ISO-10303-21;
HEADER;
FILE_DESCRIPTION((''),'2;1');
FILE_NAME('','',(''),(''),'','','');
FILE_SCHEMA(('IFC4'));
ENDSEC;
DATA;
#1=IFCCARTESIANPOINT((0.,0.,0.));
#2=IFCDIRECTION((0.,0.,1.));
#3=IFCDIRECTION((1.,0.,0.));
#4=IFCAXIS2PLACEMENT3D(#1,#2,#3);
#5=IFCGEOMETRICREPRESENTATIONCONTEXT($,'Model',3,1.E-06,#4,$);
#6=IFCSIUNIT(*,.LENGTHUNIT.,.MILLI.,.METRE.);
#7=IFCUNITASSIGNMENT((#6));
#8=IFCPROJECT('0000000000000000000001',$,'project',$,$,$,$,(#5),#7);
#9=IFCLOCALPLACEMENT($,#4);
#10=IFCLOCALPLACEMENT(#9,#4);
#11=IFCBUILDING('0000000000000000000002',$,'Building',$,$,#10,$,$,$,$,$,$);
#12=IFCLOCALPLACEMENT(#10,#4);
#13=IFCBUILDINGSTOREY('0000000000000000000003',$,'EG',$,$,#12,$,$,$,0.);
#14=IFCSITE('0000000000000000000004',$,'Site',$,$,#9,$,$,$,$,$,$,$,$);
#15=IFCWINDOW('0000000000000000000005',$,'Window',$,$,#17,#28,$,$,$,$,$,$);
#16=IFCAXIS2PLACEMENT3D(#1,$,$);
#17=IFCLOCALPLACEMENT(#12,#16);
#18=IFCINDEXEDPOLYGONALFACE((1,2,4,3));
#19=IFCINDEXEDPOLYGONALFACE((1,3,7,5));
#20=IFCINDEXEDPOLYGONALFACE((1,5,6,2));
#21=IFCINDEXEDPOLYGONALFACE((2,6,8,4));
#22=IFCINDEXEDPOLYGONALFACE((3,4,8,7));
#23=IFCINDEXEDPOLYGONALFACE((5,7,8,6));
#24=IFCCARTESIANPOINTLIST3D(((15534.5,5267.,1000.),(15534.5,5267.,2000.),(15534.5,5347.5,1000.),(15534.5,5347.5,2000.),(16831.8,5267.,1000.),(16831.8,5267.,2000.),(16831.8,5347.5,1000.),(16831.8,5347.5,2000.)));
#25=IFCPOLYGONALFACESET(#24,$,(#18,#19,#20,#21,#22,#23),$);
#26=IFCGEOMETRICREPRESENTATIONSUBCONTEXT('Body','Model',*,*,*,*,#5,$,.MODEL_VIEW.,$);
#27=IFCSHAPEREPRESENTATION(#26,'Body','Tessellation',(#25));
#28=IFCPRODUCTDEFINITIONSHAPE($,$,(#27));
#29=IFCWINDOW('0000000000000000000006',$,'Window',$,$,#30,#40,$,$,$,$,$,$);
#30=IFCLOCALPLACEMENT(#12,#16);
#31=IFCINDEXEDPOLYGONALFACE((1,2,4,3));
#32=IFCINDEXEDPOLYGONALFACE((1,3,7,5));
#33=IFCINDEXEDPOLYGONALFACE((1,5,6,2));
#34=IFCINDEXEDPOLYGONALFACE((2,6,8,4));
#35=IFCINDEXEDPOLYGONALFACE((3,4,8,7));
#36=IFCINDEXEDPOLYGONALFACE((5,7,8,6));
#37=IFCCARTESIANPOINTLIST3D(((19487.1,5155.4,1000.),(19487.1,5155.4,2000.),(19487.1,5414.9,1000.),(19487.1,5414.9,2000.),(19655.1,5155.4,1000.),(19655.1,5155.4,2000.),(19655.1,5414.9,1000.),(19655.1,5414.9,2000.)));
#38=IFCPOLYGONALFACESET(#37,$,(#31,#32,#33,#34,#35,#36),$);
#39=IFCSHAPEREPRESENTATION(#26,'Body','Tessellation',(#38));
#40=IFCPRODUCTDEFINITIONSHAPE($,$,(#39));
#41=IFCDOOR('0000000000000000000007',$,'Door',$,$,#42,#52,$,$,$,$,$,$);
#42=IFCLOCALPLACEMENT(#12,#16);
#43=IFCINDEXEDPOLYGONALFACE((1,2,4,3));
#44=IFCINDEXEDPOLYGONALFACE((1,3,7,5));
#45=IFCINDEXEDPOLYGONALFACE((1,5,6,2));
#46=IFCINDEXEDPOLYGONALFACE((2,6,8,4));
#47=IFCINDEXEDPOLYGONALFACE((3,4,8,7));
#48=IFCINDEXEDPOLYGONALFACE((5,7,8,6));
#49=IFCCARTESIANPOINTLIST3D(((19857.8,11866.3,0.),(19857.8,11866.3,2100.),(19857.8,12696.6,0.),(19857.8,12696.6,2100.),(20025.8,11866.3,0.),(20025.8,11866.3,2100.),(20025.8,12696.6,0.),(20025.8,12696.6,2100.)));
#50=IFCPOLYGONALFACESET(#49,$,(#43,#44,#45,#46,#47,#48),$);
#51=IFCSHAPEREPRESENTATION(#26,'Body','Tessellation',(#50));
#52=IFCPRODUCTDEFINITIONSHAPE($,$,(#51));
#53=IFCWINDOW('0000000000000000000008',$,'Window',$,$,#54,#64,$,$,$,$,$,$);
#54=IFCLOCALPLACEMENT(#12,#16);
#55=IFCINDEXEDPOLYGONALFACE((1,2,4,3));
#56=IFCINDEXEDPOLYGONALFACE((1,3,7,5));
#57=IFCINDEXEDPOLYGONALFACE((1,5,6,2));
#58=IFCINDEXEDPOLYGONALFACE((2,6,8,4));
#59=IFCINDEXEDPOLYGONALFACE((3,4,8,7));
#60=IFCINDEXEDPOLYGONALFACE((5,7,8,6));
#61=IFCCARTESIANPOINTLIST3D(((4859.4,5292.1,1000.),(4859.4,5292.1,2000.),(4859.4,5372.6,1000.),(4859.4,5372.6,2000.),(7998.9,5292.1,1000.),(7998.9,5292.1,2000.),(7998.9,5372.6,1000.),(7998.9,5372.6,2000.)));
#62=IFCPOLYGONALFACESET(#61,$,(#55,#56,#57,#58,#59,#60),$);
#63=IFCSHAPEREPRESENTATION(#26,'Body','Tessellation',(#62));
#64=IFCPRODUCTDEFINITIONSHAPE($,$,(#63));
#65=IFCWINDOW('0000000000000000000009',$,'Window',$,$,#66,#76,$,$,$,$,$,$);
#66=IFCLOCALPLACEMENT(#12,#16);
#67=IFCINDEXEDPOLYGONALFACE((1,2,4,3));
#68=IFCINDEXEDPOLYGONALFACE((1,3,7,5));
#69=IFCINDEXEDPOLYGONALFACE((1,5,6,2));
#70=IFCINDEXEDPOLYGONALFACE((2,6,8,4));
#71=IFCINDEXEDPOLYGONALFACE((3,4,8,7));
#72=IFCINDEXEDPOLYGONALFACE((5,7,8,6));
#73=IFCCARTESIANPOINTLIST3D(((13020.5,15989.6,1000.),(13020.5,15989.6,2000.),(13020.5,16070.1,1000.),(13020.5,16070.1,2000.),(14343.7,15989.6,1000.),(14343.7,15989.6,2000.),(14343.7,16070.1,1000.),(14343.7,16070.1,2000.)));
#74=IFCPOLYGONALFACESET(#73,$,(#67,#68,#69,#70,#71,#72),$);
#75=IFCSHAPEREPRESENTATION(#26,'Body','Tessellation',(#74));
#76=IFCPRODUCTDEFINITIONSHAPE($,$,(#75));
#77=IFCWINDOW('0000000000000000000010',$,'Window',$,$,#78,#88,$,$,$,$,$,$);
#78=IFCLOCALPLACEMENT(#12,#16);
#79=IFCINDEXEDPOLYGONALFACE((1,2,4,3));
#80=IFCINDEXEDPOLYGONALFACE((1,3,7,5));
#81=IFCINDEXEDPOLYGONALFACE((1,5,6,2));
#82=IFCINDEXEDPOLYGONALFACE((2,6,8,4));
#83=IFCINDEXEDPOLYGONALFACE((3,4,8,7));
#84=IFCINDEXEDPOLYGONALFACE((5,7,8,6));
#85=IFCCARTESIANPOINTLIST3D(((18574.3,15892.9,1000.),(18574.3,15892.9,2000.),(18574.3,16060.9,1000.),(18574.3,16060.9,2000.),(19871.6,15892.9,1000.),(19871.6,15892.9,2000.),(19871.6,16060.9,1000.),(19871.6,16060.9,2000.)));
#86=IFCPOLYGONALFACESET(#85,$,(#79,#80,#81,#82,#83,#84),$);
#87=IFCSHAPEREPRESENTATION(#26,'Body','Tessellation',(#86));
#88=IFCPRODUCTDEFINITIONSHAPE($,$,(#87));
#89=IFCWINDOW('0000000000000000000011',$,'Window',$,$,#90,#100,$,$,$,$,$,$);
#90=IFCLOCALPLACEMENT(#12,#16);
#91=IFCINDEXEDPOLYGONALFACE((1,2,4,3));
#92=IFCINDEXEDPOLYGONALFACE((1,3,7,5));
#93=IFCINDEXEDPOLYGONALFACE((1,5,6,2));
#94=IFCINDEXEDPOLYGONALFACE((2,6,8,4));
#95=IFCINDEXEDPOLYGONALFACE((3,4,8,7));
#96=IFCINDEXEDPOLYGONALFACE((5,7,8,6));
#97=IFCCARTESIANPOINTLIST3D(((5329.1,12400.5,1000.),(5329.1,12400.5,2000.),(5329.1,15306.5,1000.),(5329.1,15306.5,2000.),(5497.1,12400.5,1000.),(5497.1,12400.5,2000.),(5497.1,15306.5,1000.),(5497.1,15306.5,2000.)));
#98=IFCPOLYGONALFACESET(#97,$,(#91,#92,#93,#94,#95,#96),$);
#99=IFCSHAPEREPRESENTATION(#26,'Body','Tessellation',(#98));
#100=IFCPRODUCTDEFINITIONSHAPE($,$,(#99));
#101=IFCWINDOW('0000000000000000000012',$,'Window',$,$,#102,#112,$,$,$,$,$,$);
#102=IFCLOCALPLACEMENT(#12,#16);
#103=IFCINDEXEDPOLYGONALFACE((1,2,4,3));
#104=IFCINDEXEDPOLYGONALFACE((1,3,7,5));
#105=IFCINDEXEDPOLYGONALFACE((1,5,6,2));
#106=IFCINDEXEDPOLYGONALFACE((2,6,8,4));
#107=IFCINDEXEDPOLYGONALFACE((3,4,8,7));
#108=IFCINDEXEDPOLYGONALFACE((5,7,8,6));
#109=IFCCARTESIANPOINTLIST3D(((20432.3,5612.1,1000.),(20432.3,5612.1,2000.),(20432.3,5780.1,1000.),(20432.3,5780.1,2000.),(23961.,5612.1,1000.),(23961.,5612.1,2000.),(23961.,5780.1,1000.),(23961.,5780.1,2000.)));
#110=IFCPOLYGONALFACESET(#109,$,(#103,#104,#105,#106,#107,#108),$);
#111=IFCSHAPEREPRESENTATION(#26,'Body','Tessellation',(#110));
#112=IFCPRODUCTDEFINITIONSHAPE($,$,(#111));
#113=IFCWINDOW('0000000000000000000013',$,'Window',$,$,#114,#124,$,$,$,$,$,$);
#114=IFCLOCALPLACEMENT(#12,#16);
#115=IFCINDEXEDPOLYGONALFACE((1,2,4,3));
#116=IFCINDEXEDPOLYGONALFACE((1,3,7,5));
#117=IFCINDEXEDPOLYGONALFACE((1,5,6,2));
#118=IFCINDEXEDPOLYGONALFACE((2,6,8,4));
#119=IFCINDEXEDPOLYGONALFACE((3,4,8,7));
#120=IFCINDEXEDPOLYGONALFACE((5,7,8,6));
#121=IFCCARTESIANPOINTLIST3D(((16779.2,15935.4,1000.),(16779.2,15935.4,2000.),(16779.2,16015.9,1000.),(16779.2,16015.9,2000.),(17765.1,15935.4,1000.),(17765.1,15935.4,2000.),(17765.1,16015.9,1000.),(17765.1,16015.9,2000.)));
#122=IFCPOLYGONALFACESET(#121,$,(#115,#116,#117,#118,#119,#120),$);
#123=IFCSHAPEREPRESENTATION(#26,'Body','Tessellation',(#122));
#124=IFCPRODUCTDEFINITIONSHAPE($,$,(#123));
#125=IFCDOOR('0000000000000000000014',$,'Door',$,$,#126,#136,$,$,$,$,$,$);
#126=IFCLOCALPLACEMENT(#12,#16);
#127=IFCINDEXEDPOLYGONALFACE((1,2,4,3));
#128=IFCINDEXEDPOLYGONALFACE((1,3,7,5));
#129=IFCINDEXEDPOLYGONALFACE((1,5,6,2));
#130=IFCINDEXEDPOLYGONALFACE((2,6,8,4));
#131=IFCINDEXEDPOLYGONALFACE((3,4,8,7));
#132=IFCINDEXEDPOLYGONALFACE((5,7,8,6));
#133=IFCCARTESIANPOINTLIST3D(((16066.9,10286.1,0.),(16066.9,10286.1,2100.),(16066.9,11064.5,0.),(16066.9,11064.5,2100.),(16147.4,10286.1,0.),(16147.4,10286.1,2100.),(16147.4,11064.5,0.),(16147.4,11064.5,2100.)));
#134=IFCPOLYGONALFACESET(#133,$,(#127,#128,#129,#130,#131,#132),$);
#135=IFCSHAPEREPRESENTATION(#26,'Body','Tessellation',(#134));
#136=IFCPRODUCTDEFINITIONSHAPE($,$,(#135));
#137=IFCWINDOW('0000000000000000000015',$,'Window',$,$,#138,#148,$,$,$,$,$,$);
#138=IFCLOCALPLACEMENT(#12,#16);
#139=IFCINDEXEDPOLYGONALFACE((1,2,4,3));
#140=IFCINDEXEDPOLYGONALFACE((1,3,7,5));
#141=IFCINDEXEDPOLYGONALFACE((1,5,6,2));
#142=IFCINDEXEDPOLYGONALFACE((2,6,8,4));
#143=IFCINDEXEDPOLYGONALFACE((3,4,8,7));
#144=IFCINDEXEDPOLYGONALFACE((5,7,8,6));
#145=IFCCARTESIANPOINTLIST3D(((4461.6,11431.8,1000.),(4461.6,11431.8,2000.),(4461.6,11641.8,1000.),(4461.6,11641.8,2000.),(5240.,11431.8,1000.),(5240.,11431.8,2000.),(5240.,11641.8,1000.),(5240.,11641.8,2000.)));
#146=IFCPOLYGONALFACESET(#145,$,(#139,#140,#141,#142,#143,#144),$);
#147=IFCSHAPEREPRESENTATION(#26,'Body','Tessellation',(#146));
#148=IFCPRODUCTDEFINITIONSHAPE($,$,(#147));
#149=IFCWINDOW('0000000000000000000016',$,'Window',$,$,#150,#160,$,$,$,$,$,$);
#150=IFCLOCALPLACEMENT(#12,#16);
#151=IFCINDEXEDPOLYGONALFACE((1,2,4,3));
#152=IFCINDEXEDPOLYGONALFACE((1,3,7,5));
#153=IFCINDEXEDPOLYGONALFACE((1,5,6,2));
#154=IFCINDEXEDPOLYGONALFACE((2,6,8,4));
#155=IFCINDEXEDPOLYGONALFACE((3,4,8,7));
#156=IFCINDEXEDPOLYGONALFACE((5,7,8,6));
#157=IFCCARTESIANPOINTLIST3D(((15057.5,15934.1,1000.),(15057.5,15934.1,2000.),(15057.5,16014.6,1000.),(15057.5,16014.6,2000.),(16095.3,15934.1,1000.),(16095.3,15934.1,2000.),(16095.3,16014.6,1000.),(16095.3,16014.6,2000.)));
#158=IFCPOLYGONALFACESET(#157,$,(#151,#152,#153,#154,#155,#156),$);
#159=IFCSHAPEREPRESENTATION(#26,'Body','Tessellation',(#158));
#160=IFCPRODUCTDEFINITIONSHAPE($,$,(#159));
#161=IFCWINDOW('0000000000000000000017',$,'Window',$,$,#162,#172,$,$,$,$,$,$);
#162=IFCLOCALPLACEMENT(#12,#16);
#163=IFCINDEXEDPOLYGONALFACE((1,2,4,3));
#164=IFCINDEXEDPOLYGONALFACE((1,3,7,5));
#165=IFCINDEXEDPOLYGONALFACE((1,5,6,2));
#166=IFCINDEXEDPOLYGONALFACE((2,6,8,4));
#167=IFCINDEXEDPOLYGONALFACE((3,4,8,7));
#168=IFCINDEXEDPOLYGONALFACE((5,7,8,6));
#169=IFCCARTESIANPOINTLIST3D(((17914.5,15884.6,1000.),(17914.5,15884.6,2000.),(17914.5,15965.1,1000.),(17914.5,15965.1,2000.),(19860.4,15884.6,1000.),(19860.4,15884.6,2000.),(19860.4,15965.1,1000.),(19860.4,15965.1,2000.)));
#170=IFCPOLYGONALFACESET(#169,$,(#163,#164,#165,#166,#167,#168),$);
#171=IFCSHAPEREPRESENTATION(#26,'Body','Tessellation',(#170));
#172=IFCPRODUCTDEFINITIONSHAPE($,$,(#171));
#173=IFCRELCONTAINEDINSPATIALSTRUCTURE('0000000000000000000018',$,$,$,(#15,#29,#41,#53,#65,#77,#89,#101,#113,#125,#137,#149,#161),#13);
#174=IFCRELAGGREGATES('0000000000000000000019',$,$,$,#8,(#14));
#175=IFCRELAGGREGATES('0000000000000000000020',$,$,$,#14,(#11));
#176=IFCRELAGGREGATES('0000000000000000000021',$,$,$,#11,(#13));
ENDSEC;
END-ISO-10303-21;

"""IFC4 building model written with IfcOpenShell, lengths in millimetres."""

from ifc_helpers import new_model, si_unit, frame, origin_with_axes, place, context, subcontext, project, spatial, rectangle, extrude, element, save


model = new_model("IFC4")

# Units and contexts
model_context = context("Model", 3, precision=1e-06, world=origin_with_axes())
body_context = subcontext(model_context, "Body", "Model", "MODEL_VIEW")
ifc_project = project(units=[si_unit("LENGTHUNIT", "METRE", prefix="MILLI")], contexts=[model_context])

# Site, building, storey
site_placement = place(None, origin_with_axes())
site = spatial("IfcSite", under=ifc_project, at=site_placement, Name="Site")
building_placement = place(site_placement, origin_with_axes())
building = spatial("IfcBuilding", under=site, at=building_placement, Name="Building")
storey_placement = place(building_placement, origin_with_axes())
storey = spatial("IfcBuildingStorey", under=building, at=storey_placement, Name="EG", Elevation=0.0)

# Windows
window_1_placement = place(storey_placement, origin_with_axes())
element("IfcWindow", 1, at=window_1_placement, inside=storey, Name="Window", context=body_context, shape_type="SweptSolid", body=[
    extrude(rectangle(XDim=1297.3, YDim=80.5), frame((16183.1, 5307.2, 1000.0), z_axis=(0.0, 0.0, 1.0), x_axis=(1.0, 0.0, 0.0)), (0.0, 0.0, 1.0), 1000.0),
])
window_2_placement = place(storey_placement, origin_with_axes())
element("IfcWindow", 2, at=window_2_placement, inside=storey, Name="Window", context=body_context, shape_type="SweptSolid", body=[
    extrude(rectangle(XDim=259.5, YDim=168.0), frame((19571.1, 5285.1, 1000.0), z_axis=(0.0, 0.0, 1.0), x_axis=(0.0, 1.0, 0.0)), (0.0, 0.0, 1.0), 1000.0),
])

# Door
door_1_placement = place(storey_placement, origin_with_axes())
element("IfcDoor", 3, at=door_1_placement, inside=storey, Name="Door", context=body_context, shape_type="SweptSolid", body=[
    extrude(rectangle(XDim=830.3, YDim=168.0), frame((19941.8, 12281.5, 0.0), z_axis=(0.0, 0.0, 1.0), x_axis=(0.0, 1.0, 0.0)), (0.0, 0.0, 1.0), 2100.0),
])

# Windows
window_3_placement = place(storey_placement, origin_with_axes())
element("IfcWindow", 4, at=window_3_placement, inside=storey, Name="Window", context=body_context, shape_type="SweptSolid", body=[
    extrude(rectangle(XDim=3139.5, YDim=80.5), frame((6429.2, 5332.4, 1000.0), z_axis=(0.0, 0.0, 1.0), x_axis=(1.0, 0.0, 0.0)), (0.0, 0.0, 1.0), 1000.0),
])
window_4_placement = place(storey_placement, origin_with_axes())
element("IfcWindow", 5, at=window_4_placement, inside=storey, Name="Window", context=body_context, shape_type="SweptSolid", body=[
    extrude(rectangle(XDim=1323.3, YDim=80.5), frame((13682.1, 16029.9, 1000.0), z_axis=(0.0, 0.0, 1.0), x_axis=(1.0, 0.0, 0.0)), (0.0, 0.0, 1.0), 1000.0),
])
window_5_placement = place(storey_placement, origin_with_axes())
element("IfcWindow", 6, at=window_5_placement, inside=storey, Name="Window", context=body_context, shape_type="SweptSolid", body=[
    extrude(rectangle(XDim=1297.3, YDim=168.0), frame((19222.9, 15976.9, 1000.0), z_axis=(0.0, 0.0, 1.0), x_axis=(1.0, 0.0, 0.0)), (0.0, 0.0, 1.0), 1000.0),
])
window_6_placement = place(storey_placement, origin_with_axes())
element("IfcWindow", 7, at=window_6_placement, inside=storey, Name="Window", context=body_context, shape_type="SweptSolid", body=[
    extrude(rectangle(XDim=2906.0, YDim=168.0), frame((5413.1, 13853.5, 1000.0), z_axis=(0.0, 0.0, 1.0), x_axis=(0.0, 1.0, 0.0)), (0.0, 0.0, 1.0), 1000.0),
])
window_7_placement = place(storey_placement, origin_with_axes())
element("IfcWindow", 8, at=window_7_placement, inside=storey, Name="Window", context=body_context, shape_type="SweptSolid", body=[
    extrude(rectangle(XDim=3528.7, YDim=168.0), frame((22196.6, 5696.1, 1000.0), z_axis=(0.0, 0.0, 1.0), x_axis=(1.0, 0.0, 0.0)), (0.0, 0.0, 1.0), 1000.0),
])
window_8_placement = place(storey_placement, origin_with_axes())
element("IfcWindow", 9, at=window_8_placement, inside=storey, Name="Window", context=body_context, shape_type="SweptSolid", body=[
    extrude(rectangle(XDim=986.0, YDim=80.5), frame((17272.2, 15975.6, 1000.0), z_axis=(0.0, 0.0, 1.0), x_axis=(1.0, 0.0, 0.0)), (0.0, 0.0, 1.0), 1000.0),
])

# Door
door_2_placement = place(storey_placement, origin_with_axes())
element("IfcDoor", 10, at=door_2_placement, inside=storey, Name="Door", context=body_context, shape_type="SweptSolid", body=[
    extrude(rectangle(XDim=778.4, YDim=80.5), frame((16107.1, 10675.3, 0.0), z_axis=(0.0, 0.0, 1.0), x_axis=(0.0, 1.0, 0.0)), (0.0, 0.0, 1.0), 2100.0),
])

# Windows
window_9_placement = place(storey_placement, origin_with_axes())
element("IfcWindow", 11, at=window_9_placement, inside=storey, Name="Window", context=body_context, shape_type="SweptSolid", body=[
    extrude(rectangle(XDim=778.4, YDim=210.0), frame((4850.8, 11536.8, 1000.0), z_axis=(0.0, 0.0, 1.0), x_axis=(1.0, 0.0, 0.0)), (0.0, 0.0, 1.0), 1000.0),
])
window_10_placement = place(storey_placement, origin_with_axes())
element("IfcWindow", 12, at=window_10_placement, inside=storey, Name="Window", context=body_context, shape_type="SweptSolid", body=[
    extrude(rectangle(XDim=1037.8, YDim=80.5), frame((15576.4, 15974.3, 1000.0), z_axis=(0.0, 0.0, 1.0), x_axis=(1.0, 0.0, 0.0)), (0.0, 0.0, 1.0), 1000.0),
])
window_11_placement = place(storey_placement, origin_with_axes())
element("IfcWindow", 13, at=window_11_placement, inside=storey, Name="Window", context=body_context, shape_type="SweptSolid", body=[
    extrude(rectangle(XDim=1946.0, YDim=80.5), frame((18887.5, 15924.8, 1000.0), z_axis=(0.0, 0.0, 1.0), x_axis=(1.0, 0.0, 0.0)), (0.0, 0.0, 1.0), 1000.0),
])

save(model, "model.ifc")
